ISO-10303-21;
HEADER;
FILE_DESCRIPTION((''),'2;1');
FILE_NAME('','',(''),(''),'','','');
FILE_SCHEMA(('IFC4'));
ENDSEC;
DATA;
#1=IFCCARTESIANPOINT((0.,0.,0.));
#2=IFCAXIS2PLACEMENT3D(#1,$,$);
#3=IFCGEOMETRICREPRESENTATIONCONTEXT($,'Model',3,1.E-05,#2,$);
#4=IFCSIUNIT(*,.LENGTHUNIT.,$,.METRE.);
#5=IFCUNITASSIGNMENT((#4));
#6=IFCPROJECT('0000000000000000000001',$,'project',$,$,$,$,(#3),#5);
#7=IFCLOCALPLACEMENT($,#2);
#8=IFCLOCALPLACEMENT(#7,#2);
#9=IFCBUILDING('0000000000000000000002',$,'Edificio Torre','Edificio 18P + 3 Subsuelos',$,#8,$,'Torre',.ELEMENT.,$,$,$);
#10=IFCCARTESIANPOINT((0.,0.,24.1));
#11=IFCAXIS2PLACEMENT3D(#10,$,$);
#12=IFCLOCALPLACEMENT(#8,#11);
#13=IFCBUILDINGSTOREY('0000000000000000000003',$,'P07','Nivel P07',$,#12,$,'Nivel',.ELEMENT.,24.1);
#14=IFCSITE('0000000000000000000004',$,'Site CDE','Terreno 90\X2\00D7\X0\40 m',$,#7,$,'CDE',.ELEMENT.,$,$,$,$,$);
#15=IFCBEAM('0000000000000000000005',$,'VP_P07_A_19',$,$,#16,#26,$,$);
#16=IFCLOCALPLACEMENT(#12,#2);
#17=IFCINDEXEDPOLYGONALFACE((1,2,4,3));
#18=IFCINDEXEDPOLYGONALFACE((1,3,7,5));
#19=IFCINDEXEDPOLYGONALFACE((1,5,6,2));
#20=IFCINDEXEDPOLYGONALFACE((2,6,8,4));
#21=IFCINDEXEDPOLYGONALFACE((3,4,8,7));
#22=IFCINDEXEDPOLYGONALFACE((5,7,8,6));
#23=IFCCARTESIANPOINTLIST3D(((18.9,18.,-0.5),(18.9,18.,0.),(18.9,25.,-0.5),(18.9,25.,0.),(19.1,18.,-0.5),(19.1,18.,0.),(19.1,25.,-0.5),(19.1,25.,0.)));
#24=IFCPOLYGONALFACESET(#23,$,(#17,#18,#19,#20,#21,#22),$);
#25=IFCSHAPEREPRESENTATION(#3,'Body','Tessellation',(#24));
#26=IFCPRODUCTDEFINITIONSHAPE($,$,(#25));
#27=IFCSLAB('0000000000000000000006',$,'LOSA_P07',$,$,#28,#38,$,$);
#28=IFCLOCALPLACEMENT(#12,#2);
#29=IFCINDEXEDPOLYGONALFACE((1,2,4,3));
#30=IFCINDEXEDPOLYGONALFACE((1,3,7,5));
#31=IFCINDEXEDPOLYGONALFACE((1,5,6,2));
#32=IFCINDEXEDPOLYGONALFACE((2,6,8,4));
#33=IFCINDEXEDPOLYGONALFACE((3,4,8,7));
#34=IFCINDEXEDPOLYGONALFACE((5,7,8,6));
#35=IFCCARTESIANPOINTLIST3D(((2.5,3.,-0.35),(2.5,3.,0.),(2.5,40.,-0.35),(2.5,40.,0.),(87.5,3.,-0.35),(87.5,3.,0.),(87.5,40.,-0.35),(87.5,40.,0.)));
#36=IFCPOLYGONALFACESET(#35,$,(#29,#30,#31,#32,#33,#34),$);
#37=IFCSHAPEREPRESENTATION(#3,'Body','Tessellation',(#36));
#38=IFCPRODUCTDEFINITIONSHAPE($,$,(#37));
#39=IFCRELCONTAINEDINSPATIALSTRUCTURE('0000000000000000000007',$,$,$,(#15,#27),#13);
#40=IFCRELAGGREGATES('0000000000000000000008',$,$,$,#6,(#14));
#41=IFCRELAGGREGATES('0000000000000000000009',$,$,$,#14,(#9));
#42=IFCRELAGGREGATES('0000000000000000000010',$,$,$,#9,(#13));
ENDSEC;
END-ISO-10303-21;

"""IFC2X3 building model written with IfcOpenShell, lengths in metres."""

from ifc_helpers import new_model, si_unit, frame, origin, origin_2d, place, context, project, spatial, rectangle, extrude, element, save


model = new_model("IFC2X3")

# Units and contexts
model_context = context("Model", 3, precision=1e-05, world=origin())
ifc_project = project(units=[si_unit("LENGTHUNIT", "METRE")], contexts=[model_context])

# Site, building, storey
site_placement = place(None, origin())
site = spatial("IfcSite", under=ifc_project, at=site_placement, Name="Site CDE", Description="Terreno 90×40 m", LongName="CDE", CompositionType="ELEMENT")
building_placement = place(site_placement, origin())
building = spatial("IfcBuilding", under=site, at=building_placement, Name="Edificio Torre", Description="Edificio 18P + 3 Subsuelos", LongName="Torre", CompositionType="ELEMENT")
storey_placement = place(building_placement, frame((0.0, 0.0, 24.1)))
storey = spatial("IfcBuildingStorey", under=building, at=storey_placement, Name="P07", Description="Nivel P07", LongName="Nivel", CompositionType="ELEMENT", Elevation=24.1)

# Beam
beam_1_placement = place(storey_placement, frame((19.0, 21.5, -0.5)))
element("IfcBeam", 1, at=beam_1_placement, inside=storey, Name="VP_P07_A_19", context=model_context, shape_type="SweptSolid", body=[
    extrude(rectangle(XDim=0.2, YDim=7.0, at=origin_2d()), origin(), (0.0, 0.0, 1.0), 0.5),
])

# Slab
slab_placement = place(storey_placement, frame((45.0, 21.5, -0.35)))
element("IfcSlab", 2, at=slab_placement, inside=storey, Name="LOSA_P07", context=model_context, shape_type="SweptSolid", body=[
    extrude(rectangle(XDim=85.0, YDim=37.0, at=origin_2d()), origin(), (0.0, 0.0, 1.0), 0.35),
])

save(model, "model.ifc")
